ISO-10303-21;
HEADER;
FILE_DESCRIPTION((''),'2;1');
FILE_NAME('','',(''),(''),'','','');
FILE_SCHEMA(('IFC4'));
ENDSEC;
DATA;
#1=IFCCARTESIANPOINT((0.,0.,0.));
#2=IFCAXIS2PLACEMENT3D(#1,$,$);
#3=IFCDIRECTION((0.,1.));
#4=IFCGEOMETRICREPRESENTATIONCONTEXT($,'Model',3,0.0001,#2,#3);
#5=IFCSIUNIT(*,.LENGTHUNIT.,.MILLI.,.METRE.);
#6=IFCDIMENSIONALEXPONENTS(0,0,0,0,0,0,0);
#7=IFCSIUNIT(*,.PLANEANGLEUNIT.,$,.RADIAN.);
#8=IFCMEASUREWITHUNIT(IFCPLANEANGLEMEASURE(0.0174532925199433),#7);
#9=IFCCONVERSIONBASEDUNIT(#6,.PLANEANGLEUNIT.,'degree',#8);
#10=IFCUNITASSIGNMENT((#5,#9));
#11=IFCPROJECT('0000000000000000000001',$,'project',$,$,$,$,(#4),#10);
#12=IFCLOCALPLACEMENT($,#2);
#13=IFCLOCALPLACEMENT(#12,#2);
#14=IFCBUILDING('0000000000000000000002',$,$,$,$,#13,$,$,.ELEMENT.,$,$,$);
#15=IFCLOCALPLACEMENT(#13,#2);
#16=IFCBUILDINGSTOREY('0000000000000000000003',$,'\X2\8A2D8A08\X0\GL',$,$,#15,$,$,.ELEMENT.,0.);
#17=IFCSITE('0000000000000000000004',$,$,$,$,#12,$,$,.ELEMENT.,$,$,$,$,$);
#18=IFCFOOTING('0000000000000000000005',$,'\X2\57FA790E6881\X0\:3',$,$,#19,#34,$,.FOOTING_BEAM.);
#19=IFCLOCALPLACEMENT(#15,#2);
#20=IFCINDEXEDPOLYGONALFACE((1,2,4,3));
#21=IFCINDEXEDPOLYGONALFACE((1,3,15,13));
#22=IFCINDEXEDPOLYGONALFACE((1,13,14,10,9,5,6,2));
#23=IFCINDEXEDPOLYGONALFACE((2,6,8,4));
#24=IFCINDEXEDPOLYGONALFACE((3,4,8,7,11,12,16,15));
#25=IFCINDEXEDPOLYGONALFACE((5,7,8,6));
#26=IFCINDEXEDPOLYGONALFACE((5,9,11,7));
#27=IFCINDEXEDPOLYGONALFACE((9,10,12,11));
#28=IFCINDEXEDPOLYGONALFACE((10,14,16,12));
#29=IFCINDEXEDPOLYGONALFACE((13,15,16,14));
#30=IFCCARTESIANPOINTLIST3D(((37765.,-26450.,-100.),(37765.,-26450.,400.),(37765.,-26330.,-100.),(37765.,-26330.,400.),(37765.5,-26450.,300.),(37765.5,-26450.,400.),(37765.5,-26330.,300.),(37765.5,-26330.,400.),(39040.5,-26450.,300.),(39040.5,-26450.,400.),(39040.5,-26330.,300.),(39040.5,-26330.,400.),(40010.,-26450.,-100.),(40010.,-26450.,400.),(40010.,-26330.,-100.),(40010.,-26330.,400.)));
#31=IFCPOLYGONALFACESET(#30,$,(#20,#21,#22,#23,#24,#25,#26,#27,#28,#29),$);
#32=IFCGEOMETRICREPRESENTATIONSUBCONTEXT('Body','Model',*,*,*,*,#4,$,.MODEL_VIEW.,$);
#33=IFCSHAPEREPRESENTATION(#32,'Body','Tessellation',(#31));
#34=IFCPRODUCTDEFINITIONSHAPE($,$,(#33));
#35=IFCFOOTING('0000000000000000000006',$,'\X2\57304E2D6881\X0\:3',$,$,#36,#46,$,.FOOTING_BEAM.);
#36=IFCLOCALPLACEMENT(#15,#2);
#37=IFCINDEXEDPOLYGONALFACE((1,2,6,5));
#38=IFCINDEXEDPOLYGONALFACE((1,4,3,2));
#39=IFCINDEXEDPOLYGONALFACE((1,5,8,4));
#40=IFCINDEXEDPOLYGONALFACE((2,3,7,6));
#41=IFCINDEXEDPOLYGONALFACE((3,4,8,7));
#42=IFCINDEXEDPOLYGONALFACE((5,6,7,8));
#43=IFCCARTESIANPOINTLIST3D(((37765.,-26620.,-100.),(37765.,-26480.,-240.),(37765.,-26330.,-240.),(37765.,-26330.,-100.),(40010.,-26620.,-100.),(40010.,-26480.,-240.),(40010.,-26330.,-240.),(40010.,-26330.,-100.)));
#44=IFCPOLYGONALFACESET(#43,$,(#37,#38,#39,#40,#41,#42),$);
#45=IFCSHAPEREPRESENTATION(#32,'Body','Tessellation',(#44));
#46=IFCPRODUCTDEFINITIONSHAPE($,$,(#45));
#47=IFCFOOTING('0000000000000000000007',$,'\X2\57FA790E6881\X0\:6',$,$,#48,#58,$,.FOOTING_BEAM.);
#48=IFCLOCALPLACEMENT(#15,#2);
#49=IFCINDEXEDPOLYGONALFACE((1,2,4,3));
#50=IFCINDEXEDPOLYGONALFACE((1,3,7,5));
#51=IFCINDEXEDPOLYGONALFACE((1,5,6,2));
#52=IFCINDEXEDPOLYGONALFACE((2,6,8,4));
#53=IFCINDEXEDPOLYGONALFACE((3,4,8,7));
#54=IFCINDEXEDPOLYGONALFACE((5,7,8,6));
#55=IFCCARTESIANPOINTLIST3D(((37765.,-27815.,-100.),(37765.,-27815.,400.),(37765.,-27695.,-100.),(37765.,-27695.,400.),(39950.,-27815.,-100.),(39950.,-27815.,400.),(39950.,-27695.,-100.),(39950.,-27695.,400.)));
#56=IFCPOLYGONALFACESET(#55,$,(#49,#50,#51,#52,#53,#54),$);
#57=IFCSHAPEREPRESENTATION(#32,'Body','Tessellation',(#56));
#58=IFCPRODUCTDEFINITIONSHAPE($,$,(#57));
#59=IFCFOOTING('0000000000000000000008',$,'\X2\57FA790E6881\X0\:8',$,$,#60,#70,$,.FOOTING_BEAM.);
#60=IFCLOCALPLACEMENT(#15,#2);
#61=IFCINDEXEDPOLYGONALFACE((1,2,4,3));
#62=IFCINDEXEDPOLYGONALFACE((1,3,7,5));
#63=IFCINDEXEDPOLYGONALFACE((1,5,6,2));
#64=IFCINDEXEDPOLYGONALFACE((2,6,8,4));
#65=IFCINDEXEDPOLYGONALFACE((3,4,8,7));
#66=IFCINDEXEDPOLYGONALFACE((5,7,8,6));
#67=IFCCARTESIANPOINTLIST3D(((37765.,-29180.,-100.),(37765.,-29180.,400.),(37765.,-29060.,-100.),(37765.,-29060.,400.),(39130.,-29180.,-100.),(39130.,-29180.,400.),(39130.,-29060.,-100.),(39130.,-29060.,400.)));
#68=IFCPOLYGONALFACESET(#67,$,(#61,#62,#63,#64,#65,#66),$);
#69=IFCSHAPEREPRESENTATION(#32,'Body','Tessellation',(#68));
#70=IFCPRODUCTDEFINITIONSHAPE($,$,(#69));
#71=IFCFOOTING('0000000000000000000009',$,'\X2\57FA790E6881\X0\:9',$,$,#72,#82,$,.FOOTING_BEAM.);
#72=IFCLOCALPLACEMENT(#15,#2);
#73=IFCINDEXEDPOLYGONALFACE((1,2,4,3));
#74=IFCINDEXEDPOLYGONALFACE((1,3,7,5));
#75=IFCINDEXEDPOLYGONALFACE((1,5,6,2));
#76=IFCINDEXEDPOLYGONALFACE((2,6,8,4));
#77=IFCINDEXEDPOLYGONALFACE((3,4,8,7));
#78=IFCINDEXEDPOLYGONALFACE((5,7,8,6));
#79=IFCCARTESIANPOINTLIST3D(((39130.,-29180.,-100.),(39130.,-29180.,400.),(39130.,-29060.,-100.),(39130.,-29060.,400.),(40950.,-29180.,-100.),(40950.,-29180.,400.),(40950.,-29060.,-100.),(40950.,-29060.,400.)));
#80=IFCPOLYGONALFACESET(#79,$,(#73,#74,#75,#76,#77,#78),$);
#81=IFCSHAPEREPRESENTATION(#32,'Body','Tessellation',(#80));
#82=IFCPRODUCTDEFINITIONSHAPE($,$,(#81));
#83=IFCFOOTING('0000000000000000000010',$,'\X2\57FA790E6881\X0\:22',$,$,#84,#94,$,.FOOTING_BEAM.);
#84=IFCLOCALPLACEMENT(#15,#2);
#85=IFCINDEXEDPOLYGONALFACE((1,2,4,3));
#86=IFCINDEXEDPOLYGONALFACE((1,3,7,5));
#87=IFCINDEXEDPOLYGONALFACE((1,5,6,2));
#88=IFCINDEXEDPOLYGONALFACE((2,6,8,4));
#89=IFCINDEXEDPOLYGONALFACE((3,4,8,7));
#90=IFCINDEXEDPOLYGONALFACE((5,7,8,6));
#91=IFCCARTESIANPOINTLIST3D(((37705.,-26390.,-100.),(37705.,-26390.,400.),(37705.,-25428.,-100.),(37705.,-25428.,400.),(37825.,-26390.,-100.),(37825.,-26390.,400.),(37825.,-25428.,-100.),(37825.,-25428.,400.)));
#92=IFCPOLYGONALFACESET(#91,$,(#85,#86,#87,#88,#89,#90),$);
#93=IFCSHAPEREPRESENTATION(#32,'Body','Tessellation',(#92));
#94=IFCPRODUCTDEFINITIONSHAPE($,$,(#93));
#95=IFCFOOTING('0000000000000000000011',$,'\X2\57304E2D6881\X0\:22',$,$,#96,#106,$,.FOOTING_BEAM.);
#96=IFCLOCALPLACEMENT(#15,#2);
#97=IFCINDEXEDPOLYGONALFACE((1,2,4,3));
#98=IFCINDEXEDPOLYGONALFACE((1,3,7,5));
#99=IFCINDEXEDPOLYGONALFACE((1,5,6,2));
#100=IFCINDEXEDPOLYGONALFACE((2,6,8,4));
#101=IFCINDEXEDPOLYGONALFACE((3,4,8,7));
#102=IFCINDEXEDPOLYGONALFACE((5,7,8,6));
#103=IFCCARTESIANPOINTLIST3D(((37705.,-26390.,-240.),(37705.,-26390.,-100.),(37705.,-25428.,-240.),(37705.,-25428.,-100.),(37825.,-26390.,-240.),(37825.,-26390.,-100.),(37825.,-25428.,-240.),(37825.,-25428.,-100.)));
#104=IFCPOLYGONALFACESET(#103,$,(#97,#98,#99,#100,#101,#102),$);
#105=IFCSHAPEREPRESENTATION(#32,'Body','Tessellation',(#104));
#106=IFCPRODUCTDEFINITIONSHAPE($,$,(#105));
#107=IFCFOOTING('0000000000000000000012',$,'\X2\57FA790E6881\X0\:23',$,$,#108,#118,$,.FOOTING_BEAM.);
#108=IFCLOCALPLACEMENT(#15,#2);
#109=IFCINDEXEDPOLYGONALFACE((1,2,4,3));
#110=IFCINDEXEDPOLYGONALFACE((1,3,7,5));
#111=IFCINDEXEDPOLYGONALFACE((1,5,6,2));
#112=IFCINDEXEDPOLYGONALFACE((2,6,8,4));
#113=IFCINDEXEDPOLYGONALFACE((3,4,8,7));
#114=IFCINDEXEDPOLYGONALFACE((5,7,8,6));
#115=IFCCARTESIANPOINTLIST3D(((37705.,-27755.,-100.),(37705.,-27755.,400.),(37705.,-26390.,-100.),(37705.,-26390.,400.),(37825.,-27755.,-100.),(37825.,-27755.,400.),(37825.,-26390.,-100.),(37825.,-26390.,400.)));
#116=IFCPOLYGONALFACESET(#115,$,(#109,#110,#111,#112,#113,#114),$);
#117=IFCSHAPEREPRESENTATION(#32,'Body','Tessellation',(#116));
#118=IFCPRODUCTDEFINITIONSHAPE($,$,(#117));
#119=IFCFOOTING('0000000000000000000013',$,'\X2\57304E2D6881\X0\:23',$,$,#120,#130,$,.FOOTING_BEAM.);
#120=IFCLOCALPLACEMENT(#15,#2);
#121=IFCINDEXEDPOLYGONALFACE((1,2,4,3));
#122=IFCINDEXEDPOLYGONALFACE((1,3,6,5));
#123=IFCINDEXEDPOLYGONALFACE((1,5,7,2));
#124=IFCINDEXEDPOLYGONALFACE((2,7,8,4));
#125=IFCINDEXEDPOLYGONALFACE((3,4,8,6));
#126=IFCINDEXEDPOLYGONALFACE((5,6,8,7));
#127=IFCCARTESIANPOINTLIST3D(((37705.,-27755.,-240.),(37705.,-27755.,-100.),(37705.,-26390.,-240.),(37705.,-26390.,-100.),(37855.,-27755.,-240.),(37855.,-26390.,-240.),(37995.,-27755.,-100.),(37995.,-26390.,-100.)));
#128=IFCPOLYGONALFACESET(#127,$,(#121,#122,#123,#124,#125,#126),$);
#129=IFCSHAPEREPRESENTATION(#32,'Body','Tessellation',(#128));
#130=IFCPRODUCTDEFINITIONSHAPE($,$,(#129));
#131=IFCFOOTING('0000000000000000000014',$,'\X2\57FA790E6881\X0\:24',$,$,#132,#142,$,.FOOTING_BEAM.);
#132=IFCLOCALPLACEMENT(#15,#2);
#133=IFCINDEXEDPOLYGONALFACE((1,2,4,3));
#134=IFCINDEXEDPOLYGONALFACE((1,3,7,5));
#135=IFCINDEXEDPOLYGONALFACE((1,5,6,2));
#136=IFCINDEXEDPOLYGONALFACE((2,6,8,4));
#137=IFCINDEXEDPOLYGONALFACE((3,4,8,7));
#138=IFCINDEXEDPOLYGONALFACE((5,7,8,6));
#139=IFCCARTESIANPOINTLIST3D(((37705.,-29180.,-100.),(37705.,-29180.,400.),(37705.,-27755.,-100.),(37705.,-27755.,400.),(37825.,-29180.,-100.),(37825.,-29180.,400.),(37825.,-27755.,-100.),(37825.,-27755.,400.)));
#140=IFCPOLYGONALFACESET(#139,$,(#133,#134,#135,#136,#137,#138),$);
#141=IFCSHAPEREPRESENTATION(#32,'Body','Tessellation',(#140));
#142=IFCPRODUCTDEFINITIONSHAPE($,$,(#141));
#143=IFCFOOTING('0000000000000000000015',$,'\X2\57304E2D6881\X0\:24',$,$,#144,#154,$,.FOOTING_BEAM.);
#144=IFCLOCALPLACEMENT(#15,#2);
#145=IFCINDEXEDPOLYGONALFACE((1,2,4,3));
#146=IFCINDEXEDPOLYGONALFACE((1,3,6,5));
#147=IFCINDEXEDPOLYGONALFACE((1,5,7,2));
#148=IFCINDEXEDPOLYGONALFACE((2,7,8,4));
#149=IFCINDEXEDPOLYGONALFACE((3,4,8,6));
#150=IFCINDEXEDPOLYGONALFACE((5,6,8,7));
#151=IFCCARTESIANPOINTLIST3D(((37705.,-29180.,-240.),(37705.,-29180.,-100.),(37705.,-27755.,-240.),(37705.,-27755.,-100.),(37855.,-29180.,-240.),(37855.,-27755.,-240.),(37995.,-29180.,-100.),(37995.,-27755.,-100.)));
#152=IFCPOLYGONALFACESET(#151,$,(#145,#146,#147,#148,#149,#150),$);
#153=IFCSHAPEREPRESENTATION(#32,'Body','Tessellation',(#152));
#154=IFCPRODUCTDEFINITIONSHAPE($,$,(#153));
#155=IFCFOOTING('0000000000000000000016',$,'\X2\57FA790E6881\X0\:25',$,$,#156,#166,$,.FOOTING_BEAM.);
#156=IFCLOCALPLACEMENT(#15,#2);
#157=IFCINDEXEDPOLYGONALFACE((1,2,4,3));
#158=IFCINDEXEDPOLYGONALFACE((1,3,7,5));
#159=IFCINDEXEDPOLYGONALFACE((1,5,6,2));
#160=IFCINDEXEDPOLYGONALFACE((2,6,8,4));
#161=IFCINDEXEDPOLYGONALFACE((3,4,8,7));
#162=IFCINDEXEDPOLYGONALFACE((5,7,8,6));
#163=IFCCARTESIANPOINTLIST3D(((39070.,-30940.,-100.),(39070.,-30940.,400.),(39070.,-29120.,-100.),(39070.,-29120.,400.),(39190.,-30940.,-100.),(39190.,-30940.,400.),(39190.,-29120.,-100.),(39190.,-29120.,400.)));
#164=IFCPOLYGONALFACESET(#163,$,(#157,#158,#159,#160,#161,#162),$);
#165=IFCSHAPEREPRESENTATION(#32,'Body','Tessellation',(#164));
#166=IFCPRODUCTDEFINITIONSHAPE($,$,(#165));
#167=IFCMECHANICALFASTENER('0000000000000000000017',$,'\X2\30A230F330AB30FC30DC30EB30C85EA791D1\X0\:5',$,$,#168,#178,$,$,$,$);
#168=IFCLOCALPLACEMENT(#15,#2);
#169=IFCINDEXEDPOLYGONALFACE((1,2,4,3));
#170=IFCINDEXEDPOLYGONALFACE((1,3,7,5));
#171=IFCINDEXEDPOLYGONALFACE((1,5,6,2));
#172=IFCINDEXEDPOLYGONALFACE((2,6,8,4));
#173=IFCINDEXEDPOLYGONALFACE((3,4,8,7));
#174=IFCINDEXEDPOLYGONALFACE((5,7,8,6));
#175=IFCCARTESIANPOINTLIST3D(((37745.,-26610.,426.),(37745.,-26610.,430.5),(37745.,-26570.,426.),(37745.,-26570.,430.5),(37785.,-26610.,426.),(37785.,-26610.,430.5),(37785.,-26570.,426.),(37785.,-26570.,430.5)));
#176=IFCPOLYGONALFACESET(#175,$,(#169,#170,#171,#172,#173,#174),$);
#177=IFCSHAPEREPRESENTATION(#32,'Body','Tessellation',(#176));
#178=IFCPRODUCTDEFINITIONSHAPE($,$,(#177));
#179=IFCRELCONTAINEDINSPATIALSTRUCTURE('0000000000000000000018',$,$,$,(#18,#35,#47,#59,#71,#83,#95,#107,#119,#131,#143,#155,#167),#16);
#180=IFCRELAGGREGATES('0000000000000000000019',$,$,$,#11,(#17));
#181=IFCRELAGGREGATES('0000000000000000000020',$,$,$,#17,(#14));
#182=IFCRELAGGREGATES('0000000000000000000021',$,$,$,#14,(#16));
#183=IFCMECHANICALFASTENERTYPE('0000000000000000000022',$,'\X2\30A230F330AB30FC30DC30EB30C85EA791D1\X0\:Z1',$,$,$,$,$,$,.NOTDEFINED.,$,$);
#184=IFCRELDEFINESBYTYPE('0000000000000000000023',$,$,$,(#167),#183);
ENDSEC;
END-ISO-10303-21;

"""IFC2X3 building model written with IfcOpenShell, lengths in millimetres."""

from ifc_helpers import new_model, entity, si_unit, converted_unit, direction, frame, origin, origin_with_axes, origin_2d, place, context, subcontext, project, spatial, polyline, rectangle, outline, extrude, boolean, type_object, element, save


model = new_model("IFC2X3")

# Units and contexts
model_context = context("Model", 3, precision=0.0001, world=origin(), true_north=direction((0.0, 1.0)))
body_context = subcontext(model_context, "Body", "Model", "MODEL_VIEW")
ifc_project = project(units=[si_unit("LENGTHUNIT", "METRE", prefix="MILLI"), converted_unit("PLANEANGLEUNIT", "degree", entity("IfcPlaneAngleMeasure", 0.0174532925199433), si_unit("PLANEANGLEUNIT", "RADIAN"), dimensions=[0, 0, 0, 0, 0, 0, 0])], contexts=[model_context])

# Site, building, storey
site_placement = place(None, origin())
site = spatial("IfcSite", under=ifc_project, at=site_placement, CompositionType="ELEMENT")
building_placement = place(site_placement, origin())
building = spatial("IfcBuilding", under=site, at=building_placement, CompositionType="ELEMENT")
storey_placement = place(building_placement, origin())
storey = spatial("IfcBuildingStorey", under=building, at=storey_placement, Name="設計GL", CompositionType="ELEMENT", Elevation=0.0)

# Footings
footing_1_placement = place(storey_placement, frame((37765.0, -26390.0, 150.0), z_axis=(1.0, 0.0, 0.0), x_axis=(0.0, 1.0, 0.0)))
element("IfcFooting", 1, at=footing_1_placement, inside=storey, Name="基礎梁:3", PredefinedType="FOOTING_BEAM", context=body_context, shape_type="CSG", body=[
    boolean("DIFFERENCE", extrude(rectangle(XDim=120.0, YDim=500.0, at=origin_2d()), origin_with_axes(), (0.0, 0.0, 1.0), 2245.0), extrude(rectangle(XDim=124.0, YDim=100.0, at=origin_2d()), frame((0.0, 200.0, 0.5), z_axis=(0.0, 0.0, 1.0), x_axis=(1.0, 0.0, 0.0)), (0.0, 0.0, 1.0), 1275.0)),
])
footing_2_placement = place(storey_placement, frame((37765.0, -26330.0, -240.0), z_axis=(1.0, 0.0, 0.0), x_axis=(0.0, 1.0, 0.0)))
element("IfcFooting", 2, at=footing_2_placement, inside=storey, Name="地中梁:3", PredefinedType="FOOTING_BEAM", context=body_context, shape_type="SweptSolid", body=[
    extrude(outline(polyline([(0.0, 0.0, 0.0), (-150.0, 0.0, 0.0), (-290.0, 140.0, 0.0), (0.0, 140.0, 0.0), (0.0, 0.0, 0.0)])), origin_with_axes(), (0.0, 0.0, 1.0), 2245.0),
])
footing_3_placement = place(storey_placement, frame((37765.0, -27755.0, 150.0), z_axis=(1.0, 0.0, 0.0), x_axis=(0.0, 1.0, 0.0)))
element("IfcFooting", 3, at=footing_3_placement, inside=storey, Name="基礎梁:6", PredefinedType="FOOTING_BEAM", context=body_context, shape_type="SolidModel", body=[
    extrude(rectangle(XDim=120.0, YDim=500.0, at=origin_2d()), origin_with_axes(), (0.0, 0.0, 1.0), 2185.0),
])
footing_4_placement = place(storey_placement, frame((37765.0, -29120.0, 150.0), z_axis=(1.0, 0.0, 0.0), x_axis=(0.0, 1.0, 0.0)))
element("IfcFooting", 4, at=footing_4_placement, inside=storey, Name="基礎梁:8", PredefinedType="FOOTING_BEAM", context=body_context, shape_type="SolidModel", body=[
    extrude(rectangle(XDim=120.0, YDim=500.0, at=origin_2d()), origin_with_axes(), (0.0, 0.0, 1.0), 1365.0),
])
footing_5_placement = place(storey_placement, frame((39130.0, -29120.0, 150.0), z_axis=(1.0, 0.0, 0.0), x_axis=(0.0, 1.0, 0.0)))
element("IfcFooting", 5, at=footing_5_placement, inside=storey, Name="基礎梁:9", PredefinedType="FOOTING_BEAM", context=body_context, shape_type="SolidModel", body=[
    extrude(rectangle(XDim=120.0, YDim=500.0, at=origin_2d()), origin_with_axes(), (0.0, 0.0, 1.0), 1820.0),
])
footing_6_placement = place(storey_placement, frame((37765.0, -25428.0, 150.0), z_axis=(0.0, -1.0, 0.0), x_axis=(1.0, 0.0, 0.0)))
element("IfcFooting", 6, at=footing_6_placement, inside=storey, Name="基礎梁:22", PredefinedType="FOOTING_BEAM", context=body_context, shape_type="SolidModel", body=[
    extrude(rectangle(XDim=120.0, YDim=500.0, at=origin_2d()), origin_with_axes(), (0.0, 0.0, 1.0), 962.0),
])
footing_7_placement = place(storey_placement, frame((37705.0, -25428.0, -240.0), z_axis=(0.0, -1.0, 0.0), x_axis=(1.0, 0.0, 0.0)))
element("IfcFooting", 7, at=footing_7_placement, inside=storey, Name="地中梁:22", PredefinedType="FOOTING_BEAM", context=body_context, shape_type="SweptSolid", body=[
    extrude(outline(polyline([(0.0, 0.0, 0.0), (120.0, 0.0, 0.0), (120.0, 140.0, 0.0), (0.0, 140.0, 0.0), (0.0, 0.0, 0.0)])), origin_with_axes(), (0.0, 0.0, 1.0), 962.0),
])
footing_8_placement = place(storey_placement, frame((37765.0, -26390.0, 150.0), z_axis=(0.0, -1.0, 0.0), x_axis=(1.0, 0.0, 0.0)))
element("IfcFooting", 8, at=footing_8_placement, inside=storey, Name="基礎梁:23", PredefinedType="FOOTING_BEAM", context=body_context, shape_type="SolidModel", body=[
    extrude(rectangle(XDim=120.0, YDim=500.0, at=origin_2d()), origin_with_axes(), (0.0, 0.0, 1.0), 1365.0),
])
footing_9_placement = place(storey_placement, frame((37705.0, -26390.0, -240.0), z_axis=(0.0, -1.0, 0.0), x_axis=(1.0, 0.0, 0.0)))
element("IfcFooting", 9, at=footing_9_placement, inside=storey, Name="地中梁:23", PredefinedType="FOOTING_BEAM", context=body_context, shape_type="SweptSolid", body=[
    extrude(outline(polyline([(0.0, 0.0, 0.0), (150.0, 0.0, 0.0), (290.0, 140.0, 0.0), (0.0, 140.0, 0.0), (0.0, 0.0, 0.0)])), origin_with_axes(), (0.0, 0.0, 1.0), 1365.0),
])
footing_10_placement = place(storey_placement, frame((37765.0, -27755.0, 150.0), z_axis=(0.0, -1.0, 0.0), x_axis=(1.0, 0.0, 0.0)))
element("IfcFooting", 10, at=footing_10_placement, inside=storey, Name="基礎梁:24", PredefinedType="FOOTING_BEAM", context=body_context, shape_type="SolidModel", body=[
    extrude(rectangle(XDim=120.0, YDim=500.0, at=origin_2d()), origin_with_axes(), (0.0, 0.0, 1.0), 1425.0),
])
footing_11_placement = place(storey_placement, frame((37705.0, -27755.0, -240.0), z_axis=(0.0, -1.0, 0.0), x_axis=(1.0, 0.0, 0.0)))
element("IfcFooting", 11, at=footing_11_placement, inside=storey, Name="地中梁:24", PredefinedType="FOOTING_BEAM", context=body_context, shape_type="SweptSolid", body=[
    extrude(outline(polyline([(0.0, 0.0, 0.0), (150.0, 0.0, 0.0), (290.0, 140.0, 0.0), (0.0, 140.0, 0.0), (0.0, 0.0, 0.0)])), origin_with_axes(), (0.0, 0.0, 1.0), 1425.0),
])
footing_12_placement = place(storey_placement, frame((39130.0, -29120.0, 150.0), z_axis=(0.0, -1.0, 0.0), x_axis=(1.0, 0.0, 0.0)))
element("IfcFooting", 12, at=footing_12_placement, inside=storey, Name="基礎梁:25", PredefinedType="FOOTING_BEAM", context=body_context, shape_type="SolidModel", body=[
    extrude(rectangle(XDim=120.0, YDim=500.0, at=origin_2d()), origin_with_axes(), (0.0, 0.0, 1.0), 1820.0),
])

# Mechanical fastener
mechanical_fastener_type_1 = type_object("IfcMechanicalFastenerType", Name="アンカーボルト座金:Z1")
mechanical_fastener_1_placement = place(storey_placement, frame((37765.0, -26590.0, 426.0)))
element("IfcMechanicalFastener", 13, at=mechanical_fastener_1_placement, inside=storey, type_object=mechanical_fastener_type_1, Name="アンカーボルト座金:5", context=body_context, shape_type="SweptSolid", body=[
    extrude(rectangle(XDim=40.0, YDim=40.0, at=origin_2d()), origin_with_axes(), (0.0, 0.0, 1.0), 4.5),
])

save(model, "model.ifc")
